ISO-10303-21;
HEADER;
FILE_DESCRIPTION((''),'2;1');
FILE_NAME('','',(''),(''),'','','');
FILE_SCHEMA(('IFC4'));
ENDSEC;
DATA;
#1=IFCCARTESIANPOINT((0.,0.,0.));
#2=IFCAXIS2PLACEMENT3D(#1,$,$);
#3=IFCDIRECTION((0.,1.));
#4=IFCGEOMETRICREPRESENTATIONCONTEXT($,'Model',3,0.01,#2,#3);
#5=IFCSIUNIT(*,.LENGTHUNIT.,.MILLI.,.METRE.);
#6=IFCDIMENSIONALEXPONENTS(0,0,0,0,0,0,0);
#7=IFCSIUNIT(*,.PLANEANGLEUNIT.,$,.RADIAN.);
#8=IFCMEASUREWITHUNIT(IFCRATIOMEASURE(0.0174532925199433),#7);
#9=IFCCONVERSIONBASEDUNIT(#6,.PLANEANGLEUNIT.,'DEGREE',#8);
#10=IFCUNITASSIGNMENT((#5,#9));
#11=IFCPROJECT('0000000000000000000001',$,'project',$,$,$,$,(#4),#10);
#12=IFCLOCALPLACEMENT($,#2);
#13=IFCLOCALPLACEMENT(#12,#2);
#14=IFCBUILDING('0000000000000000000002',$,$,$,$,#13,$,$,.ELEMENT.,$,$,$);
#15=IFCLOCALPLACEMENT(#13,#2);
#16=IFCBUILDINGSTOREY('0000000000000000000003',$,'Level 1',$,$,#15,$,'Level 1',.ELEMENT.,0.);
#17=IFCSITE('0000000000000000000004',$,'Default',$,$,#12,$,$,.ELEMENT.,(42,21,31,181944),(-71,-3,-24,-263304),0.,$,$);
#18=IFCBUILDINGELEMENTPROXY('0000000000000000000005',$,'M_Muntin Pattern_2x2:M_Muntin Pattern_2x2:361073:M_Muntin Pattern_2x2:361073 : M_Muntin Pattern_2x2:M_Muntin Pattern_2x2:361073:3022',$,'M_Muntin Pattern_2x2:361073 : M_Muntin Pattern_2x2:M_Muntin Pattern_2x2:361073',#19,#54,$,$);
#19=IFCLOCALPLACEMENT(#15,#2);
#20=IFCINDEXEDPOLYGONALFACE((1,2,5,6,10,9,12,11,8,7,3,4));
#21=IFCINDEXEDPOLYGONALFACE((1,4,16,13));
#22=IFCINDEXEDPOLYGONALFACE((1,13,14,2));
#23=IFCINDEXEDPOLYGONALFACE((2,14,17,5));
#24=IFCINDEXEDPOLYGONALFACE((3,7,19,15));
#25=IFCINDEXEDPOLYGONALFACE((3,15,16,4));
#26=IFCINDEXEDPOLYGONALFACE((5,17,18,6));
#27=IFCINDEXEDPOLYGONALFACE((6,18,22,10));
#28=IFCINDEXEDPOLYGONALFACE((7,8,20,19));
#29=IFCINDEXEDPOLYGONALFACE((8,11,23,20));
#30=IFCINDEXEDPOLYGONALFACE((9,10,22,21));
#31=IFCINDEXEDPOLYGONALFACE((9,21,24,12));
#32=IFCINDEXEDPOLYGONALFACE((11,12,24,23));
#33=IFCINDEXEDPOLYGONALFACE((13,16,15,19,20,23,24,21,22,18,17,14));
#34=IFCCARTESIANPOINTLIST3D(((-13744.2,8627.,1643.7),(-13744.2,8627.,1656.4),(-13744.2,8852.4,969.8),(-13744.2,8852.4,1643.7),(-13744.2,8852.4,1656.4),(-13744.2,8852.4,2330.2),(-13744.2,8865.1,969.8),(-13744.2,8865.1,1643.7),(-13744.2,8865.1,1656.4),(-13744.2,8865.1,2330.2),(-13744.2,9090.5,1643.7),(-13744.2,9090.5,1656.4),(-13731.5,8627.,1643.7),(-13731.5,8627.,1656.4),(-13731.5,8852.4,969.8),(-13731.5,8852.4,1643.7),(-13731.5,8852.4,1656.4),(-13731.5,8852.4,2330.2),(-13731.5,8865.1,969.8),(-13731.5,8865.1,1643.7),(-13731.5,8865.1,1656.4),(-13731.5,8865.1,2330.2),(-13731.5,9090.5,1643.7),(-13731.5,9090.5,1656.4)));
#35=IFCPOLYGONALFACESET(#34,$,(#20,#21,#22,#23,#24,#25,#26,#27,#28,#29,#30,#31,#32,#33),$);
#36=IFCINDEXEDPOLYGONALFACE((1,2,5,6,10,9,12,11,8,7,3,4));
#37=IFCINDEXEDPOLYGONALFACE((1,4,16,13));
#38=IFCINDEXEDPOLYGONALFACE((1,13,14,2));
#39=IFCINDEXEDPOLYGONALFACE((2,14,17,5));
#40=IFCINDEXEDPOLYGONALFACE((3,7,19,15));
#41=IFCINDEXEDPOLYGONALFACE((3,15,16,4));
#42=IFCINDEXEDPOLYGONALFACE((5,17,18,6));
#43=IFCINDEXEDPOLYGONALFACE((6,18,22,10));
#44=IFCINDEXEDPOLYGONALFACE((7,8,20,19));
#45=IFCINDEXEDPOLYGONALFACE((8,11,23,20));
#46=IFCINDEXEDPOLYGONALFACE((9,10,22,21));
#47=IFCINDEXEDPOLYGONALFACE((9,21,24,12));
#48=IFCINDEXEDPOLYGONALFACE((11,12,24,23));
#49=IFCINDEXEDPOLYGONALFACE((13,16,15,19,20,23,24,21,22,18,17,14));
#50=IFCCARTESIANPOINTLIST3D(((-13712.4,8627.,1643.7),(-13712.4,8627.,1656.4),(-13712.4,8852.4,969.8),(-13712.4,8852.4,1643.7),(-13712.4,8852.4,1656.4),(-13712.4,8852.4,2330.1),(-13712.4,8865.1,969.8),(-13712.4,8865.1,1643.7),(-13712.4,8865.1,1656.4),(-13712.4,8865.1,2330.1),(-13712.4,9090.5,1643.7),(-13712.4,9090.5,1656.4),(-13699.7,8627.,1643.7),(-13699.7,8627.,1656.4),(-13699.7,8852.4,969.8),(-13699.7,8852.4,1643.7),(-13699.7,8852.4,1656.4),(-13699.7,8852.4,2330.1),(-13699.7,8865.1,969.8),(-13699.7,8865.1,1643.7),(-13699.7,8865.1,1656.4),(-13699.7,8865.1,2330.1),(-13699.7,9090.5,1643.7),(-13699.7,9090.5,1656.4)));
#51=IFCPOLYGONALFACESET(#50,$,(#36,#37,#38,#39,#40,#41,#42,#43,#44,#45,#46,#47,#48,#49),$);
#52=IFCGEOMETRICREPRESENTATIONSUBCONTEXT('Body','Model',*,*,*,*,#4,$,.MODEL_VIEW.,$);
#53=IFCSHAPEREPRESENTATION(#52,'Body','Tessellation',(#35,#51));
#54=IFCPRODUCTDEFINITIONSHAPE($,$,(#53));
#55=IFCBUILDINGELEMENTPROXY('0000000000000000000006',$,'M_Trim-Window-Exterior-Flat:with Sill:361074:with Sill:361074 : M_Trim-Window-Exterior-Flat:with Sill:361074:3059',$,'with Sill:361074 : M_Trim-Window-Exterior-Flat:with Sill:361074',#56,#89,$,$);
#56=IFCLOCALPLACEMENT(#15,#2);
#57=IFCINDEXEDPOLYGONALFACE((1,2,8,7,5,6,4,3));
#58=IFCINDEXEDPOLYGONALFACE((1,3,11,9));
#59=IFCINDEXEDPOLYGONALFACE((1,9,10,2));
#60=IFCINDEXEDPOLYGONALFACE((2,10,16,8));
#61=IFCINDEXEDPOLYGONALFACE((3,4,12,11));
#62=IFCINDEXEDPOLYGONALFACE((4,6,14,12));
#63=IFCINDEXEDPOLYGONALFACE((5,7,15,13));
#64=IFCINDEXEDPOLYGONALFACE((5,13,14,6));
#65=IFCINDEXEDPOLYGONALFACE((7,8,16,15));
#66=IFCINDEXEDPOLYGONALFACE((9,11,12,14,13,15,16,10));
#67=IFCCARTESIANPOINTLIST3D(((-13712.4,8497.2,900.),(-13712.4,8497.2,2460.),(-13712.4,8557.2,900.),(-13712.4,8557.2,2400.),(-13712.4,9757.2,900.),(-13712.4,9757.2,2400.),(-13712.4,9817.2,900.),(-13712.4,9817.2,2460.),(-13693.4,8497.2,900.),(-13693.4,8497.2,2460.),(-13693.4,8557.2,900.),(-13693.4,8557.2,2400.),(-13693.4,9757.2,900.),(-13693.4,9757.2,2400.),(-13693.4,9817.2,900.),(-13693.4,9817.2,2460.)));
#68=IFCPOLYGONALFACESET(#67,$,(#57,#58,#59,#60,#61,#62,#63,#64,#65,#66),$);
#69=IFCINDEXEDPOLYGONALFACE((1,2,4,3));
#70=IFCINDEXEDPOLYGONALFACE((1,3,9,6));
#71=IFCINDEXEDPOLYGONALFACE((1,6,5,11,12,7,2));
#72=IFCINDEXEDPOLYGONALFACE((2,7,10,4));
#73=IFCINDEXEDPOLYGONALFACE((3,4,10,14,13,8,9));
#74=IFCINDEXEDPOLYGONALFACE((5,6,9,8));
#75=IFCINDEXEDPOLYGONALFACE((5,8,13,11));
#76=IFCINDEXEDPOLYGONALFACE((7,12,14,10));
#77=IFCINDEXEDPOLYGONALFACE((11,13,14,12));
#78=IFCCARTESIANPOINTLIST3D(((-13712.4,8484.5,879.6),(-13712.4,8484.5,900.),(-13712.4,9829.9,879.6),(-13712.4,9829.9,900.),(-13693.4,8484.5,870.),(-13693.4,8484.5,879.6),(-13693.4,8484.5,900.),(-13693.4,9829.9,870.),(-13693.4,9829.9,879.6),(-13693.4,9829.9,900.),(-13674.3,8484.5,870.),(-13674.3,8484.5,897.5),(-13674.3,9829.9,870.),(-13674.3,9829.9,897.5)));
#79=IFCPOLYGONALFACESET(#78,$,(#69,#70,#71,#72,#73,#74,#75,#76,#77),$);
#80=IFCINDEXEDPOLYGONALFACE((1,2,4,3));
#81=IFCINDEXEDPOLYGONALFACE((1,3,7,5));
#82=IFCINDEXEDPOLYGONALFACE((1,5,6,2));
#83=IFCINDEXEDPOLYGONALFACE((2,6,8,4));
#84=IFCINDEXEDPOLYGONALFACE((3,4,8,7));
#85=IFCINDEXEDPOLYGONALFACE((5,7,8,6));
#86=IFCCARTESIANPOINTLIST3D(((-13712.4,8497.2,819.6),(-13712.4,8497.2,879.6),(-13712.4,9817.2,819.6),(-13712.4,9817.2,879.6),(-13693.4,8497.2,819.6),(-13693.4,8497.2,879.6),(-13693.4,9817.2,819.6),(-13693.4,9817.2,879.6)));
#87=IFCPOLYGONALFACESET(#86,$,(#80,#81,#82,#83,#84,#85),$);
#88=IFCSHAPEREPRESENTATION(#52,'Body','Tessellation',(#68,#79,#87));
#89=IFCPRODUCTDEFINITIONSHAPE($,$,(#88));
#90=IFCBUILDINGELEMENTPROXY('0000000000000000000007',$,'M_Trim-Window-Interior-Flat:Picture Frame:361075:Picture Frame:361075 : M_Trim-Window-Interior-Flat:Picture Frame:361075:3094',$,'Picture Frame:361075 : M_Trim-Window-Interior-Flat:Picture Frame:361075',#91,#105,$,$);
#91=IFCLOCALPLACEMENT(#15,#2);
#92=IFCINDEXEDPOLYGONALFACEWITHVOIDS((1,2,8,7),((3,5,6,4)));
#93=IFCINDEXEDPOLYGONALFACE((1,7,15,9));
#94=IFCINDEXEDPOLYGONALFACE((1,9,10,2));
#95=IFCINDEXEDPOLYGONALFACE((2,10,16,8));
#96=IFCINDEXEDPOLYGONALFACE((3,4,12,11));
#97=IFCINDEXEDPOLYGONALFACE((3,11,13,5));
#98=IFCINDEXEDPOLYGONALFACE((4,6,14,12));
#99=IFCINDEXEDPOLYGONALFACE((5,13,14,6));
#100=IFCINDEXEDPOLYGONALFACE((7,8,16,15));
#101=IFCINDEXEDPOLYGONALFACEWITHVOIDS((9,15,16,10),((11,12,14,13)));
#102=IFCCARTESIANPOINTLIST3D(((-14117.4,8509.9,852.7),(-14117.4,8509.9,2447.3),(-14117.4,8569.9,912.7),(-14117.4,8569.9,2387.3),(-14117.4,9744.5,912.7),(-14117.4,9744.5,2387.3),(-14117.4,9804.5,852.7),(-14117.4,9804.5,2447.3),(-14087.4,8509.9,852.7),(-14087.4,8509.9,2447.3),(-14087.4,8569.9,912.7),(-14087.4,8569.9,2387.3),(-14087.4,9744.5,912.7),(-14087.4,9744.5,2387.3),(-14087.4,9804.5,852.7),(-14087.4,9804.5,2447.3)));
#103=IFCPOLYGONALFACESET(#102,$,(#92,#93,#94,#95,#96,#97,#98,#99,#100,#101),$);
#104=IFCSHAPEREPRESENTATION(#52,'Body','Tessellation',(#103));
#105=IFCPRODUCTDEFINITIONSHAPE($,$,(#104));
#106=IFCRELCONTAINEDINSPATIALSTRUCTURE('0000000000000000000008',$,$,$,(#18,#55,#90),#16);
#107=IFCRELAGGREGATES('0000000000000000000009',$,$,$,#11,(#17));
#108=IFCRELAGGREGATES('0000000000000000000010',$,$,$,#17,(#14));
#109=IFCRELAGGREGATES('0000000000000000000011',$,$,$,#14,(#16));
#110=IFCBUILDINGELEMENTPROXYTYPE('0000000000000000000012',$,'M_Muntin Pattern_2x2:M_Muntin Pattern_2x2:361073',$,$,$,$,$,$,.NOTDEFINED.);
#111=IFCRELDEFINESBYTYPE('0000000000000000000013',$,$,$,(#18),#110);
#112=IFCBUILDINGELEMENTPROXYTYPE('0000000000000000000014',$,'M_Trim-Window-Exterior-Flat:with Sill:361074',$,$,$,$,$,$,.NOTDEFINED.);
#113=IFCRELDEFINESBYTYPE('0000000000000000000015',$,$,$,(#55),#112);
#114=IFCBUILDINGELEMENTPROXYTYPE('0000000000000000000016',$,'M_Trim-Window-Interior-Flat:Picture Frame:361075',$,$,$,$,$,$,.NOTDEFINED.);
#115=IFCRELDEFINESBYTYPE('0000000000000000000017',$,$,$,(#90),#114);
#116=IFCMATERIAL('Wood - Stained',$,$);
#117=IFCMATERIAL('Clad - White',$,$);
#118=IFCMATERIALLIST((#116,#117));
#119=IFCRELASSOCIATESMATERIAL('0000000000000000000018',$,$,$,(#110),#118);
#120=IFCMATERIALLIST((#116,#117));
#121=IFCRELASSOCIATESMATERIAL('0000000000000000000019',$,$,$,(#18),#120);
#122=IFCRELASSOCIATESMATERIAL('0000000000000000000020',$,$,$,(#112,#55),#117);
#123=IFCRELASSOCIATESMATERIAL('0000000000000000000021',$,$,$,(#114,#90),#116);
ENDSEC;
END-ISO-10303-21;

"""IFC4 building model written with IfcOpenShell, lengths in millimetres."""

from ifc_helpers import new_model, entity, si_unit, converted_unit, direction, frame, frame_2d, origin, place, context, subcontext, project, spatial, polyline, rectangle, outline, extrude, source, transform, mapped, material, material_list, type_object, type_shapes, element, save


model = new_model("IFC4")

# Units and contexts
model_context = context("Model", 3, precision=0.01, world=origin(), true_north=direction((0.0, 1.0)))
body_context = subcontext(model_context, "Body", "Model", "MODEL_VIEW")
ifc_project = project(units=[si_unit("LENGTHUNIT", "METRE", prefix="MILLI"), converted_unit("PLANEANGLEUNIT", "DEGREE", entity("IfcRatioMeasure", 0.0174532925199433), si_unit("PLANEANGLEUNIT", "RADIAN"), dimensions=[0, 0, 0, 0, 0, 0, 0])], contexts=[model_context])

# Site, building, storey
site_placement = place(None, origin())
site = spatial("IfcSite", under=ifc_project, at=site_placement, Name="Default", CompositionType="ELEMENT", RefLatitude=(42, 21, 31, 181944), RefLongitude=(-71, -3, -24, -263304), RefElevation=0.0)
building_placement = place(site_placement, origin())
building = spatial("IfcBuilding", under=site, at=building_placement, CompositionType="ELEMENT")
storey_placement = place(building_placement, origin())
storey = spatial("IfcBuildingStorey", under=building, at=storey_placement, Name="Level 1", LongName="Level 1", CompositionType="ELEMENT", Elevation=0.0)

# Building element proxies
ifc_material_1 = material(Name="Clad - White")
ifc_material_2 = material(Name="Wood - Stained")
ifc_material_list_1 = material_list([ifc_material_2, ifc_material_1])
ifc_material_list_2 = material_list([ifc_material_2, ifc_material_1])
building_element_proxy_type_1 = type_object("IfcBuildingElementProxyType", Name="M_Muntin Pattern_2x2:M_Muntin Pattern_2x2:361073", PredefinedType="NOTDEFINED", material=ifc_material_list_2)
shared_shape_1 = source(origin(), body_context, "Body", "SweptSolid", [
    extrude(outline(polyline([(-680.1, 6.4), (-680.1, -6.3), (-6.4, -6.3), (-6.4, -231.7), (6.3, -231.7), (6.3, -6.3), (680.2, -6.3), (680.2, 6.4), (6.3, 6.4), (6.3, 231.7), (-6.4, 231.7), (-6.4, 6.4), (-680.1, 6.4)])), frame((-13744.2, 8858.7, 1650.0), z_axis=(-1.0, 0.0, 0.0), x_axis=(0.0, 0.0, -1.0)), (0.0, 0.0, -1.0), 12.7),
    extrude(outline(polyline([(-680.1, 6.4), (-680.1, -6.3), (-6.4, -6.3), (-6.4, -231.7), (6.3, -231.7), (6.3, -6.3), (680.2, -6.3), (680.2, 6.4), (6.3, 6.4), (6.3, 231.7), (-6.4, 231.7), (-6.4, 6.4), (-680.1, 6.4)])), frame((-13712.4, 8858.7, 1650.0), z_axis=(-1.0, 0.0, 0.0), x_axis=(0.0, 0.0, -1.0)), (0.0, 0.0, -1.0), 12.7),
])
type_shapes(building_element_proxy_type_1, [shared_shape_1])
proxy_1_placement = place(storey_placement, origin())
element("IfcBuildingElementProxy", 1, at=proxy_1_placement, inside=storey, type_object=building_element_proxy_type_1, material=ifc_material_list_1, Name="M_Muntin Pattern_2x2:M_Muntin Pattern_2x2:361073:M_Muntin Pattern_2x2:361073 : M_Muntin Pattern_2x2:M_Muntin Pattern_2x2:361073:3022", ObjectType="M_Muntin Pattern_2x2:361073 : M_Muntin Pattern_2x2:M_Muntin Pattern_2x2:361073", context=body_context, shape_type="MappedRepresentation", body=[
    mapped(shared_shape_1, transform((0.0, 0.0, 0.0), scale=1.0)),
])
building_element_proxy_type_2 = type_object("IfcBuildingElementProxyType", Name="M_Trim-Window-Exterior-Flat:with Sill:361074", PredefinedType="NOTDEFINED", material=ifc_material_1)
shared_shape_2 = source(origin(), body_context, "Body", "SweptSolid", [
    extrude(outline(polyline([(-660.0, -765.0), (-600.0, -765.0), (-600.0, 735.0), (600.0, 735.0), (600.0, -765.0), (660.0, -765.0), (660.0, 795.0), (-660.0, 795.0), (-660.0, -765.0)])), frame((-13712.4, 9157.2, 1665.0), z_axis=(1.0, 0.0, 0.0), x_axis=(0.0, 1.0, 0.0)), (0.0, 0.0, 1.0), 19.1),
    extrude(outline(polyline([(-15.2, 0.0), (-15.2, -19.0), (12.3, -19.0), (14.8, 0.0), (14.8, 19.0), (-5.7, 19.0), (-5.7, 0.0), (-15.2, 0.0)])), frame((-13693.4, 8484.5, 885.2), z_axis=(0.0, -1.0, 0.0), x_axis=(0.0, 0.0, 1.0)), (0.0, 0.0, -1.0), 1345.4),
    extrude(rectangle(XDim=19.1, YDim=1320.0, at=frame_2d((0.0, 0.0), x_axis=(1.0, 0.0))), frame((-13702.9, 9157.2, 819.6), z_axis=(0.0, 0.0, 1.0), x_axis=(-1.0, 0.0, 0.0)), (0.0, 0.0, 1.0), 60.0),
])
type_shapes(building_element_proxy_type_2, [shared_shape_2])
proxy_2_placement = place(storey_placement, origin())
element("IfcBuildingElementProxy", 2, at=proxy_2_placement, inside=storey, type_object=building_element_proxy_type_2, material=ifc_material_1, Name="M_Trim-Window-Exterior-Flat:with Sill:361074:with Sill:361074 : M_Trim-Window-Exterior-Flat:with Sill:361074:3059", ObjectType="with Sill:361074 : M_Trim-Window-Exterior-Flat:with Sill:361074", context=body_context, shape_type="MappedRepresentation", body=[
    mapped(shared_shape_2, transform((0.0, 0.0, 0.0), scale=1.0)),
])
building_element_proxy_type_3 = type_object("IfcBuildingElementProxyType", Name="M_Trim-Window-Interior-Flat:Picture Frame:361075", PredefinedType="NOTDEFINED", material=ifc_material_2)
shared_shape_3 = source(origin(), body_context, "Body", "SweptSolid", [
    extrude(outline(polyline([(-647.3, -797.3), (647.3, -797.3), (647.3, 797.3), (-647.3, 797.3), (-647.3, -797.3)]), holes=[polyline([(587.3, 737.3), (587.3, -737.3), (-587.3, -737.3), (-587.3, 737.3), (587.3, 737.3)])]), frame((-14117.4, 9157.2, 1650.0), z_axis=(1.0, 0.0, 0.0), x_axis=(0.0, -1.0, 0.0)), (0.0, 0.0, 1.0), 30.0),
])
type_shapes(building_element_proxy_type_3, [shared_shape_3])
proxy_3_placement = place(storey_placement, origin())
element("IfcBuildingElementProxy", 3, at=proxy_3_placement, inside=storey, type_object=building_element_proxy_type_3, material=ifc_material_2, Name="M_Trim-Window-Interior-Flat:Picture Frame:361075:Picture Frame:361075 : M_Trim-Window-Interior-Flat:Picture Frame:361075:3094", ObjectType="Picture Frame:361075 : M_Trim-Window-Interior-Flat:Picture Frame:361075", context=body_context, shape_type="MappedRepresentation", body=[
    mapped(shared_shape_3, transform((0.0, 0.0, 0.0), scale=1.0)),
])

save(model, "model.ifc")
